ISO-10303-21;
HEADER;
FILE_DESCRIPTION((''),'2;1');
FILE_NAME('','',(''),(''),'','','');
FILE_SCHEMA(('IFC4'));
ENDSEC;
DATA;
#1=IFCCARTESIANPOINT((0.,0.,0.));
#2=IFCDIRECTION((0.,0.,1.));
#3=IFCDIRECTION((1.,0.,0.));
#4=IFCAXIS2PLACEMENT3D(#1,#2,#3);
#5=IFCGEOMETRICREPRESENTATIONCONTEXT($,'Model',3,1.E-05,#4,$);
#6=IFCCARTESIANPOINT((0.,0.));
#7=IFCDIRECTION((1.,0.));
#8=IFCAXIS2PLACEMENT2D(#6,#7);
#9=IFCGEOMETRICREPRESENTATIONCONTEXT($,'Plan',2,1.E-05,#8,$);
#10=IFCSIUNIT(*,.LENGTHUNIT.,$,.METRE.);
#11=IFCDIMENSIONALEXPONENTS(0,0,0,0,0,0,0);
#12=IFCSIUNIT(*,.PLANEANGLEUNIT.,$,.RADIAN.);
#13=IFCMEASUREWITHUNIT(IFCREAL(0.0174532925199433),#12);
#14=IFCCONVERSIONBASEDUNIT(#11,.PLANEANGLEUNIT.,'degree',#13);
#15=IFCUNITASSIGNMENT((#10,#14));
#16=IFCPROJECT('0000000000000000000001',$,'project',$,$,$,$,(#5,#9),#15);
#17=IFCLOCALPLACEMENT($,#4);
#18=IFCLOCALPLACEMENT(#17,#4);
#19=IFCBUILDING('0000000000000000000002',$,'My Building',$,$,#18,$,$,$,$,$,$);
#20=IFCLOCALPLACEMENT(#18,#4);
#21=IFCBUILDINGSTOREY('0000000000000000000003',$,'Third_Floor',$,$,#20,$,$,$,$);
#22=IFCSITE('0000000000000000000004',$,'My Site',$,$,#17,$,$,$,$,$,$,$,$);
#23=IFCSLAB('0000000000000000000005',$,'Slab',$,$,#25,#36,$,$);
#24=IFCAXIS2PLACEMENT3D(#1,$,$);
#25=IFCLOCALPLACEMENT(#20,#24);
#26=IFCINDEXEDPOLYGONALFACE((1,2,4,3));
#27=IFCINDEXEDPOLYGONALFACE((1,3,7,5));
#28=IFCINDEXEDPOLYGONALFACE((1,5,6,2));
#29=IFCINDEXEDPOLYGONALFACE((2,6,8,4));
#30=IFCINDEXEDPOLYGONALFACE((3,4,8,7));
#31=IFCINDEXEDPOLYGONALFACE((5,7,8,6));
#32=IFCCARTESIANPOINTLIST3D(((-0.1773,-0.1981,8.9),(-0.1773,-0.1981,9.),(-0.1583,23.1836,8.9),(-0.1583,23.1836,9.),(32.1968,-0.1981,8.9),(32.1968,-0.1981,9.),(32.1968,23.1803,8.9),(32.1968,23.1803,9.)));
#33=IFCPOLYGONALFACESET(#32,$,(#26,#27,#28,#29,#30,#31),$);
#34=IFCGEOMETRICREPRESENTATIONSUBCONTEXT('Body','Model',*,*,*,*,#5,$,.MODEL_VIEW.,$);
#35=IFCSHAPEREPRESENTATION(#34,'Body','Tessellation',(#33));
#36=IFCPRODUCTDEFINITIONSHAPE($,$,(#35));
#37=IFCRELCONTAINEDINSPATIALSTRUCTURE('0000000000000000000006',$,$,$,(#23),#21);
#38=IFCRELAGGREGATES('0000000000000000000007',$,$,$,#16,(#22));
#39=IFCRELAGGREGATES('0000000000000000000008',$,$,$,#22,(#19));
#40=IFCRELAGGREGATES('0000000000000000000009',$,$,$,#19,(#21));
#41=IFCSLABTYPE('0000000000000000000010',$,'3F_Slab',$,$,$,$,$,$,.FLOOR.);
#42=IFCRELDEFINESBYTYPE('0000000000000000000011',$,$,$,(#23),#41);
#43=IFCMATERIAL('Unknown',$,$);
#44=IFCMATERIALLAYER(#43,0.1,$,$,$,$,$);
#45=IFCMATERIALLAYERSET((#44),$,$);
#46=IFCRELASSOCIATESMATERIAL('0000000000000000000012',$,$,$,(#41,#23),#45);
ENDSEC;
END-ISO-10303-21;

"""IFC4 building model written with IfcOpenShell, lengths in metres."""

from ifc_helpers import new_model, entity, si_unit, converted_unit, frame, origin_with_axes, origin_2d_with_axis, place, context, subcontext, project, spatial, indexed_curve, outline, extrude, material, layer, layer_set, layer_usage, type_object, element, save


model = new_model("IFC4")

# Units and contexts
model_context = context("Model", 3, precision=1e-05, world=origin_with_axes())
plan_context = context("Plan", 2, precision=1e-05, world=origin_2d_with_axis())
body_context = subcontext(model_context, "Body", "Model", "MODEL_VIEW")
ifc_project = project(units=[si_unit("LENGTHUNIT", "METRE"), converted_unit("PLANEANGLEUNIT", "degree", entity("IfcReal", 0.0174532925199433), si_unit("PLANEANGLEUNIT", "RADIAN"), dimensions=[0, 0, 0, 0, 0, 0, 0])], contexts=[model_context, plan_context])

# Site, building, storey
site_placement = place(None, origin_with_axes())
site = spatial("IfcSite", under=ifc_project, at=site_placement, Name="My Site")
building_placement = place(site_placement, origin_with_axes())
building = spatial("IfcBuilding", under=site, at=building_placement, Name="My Building")
storey_placement = place(building_placement, origin_with_axes())
storey = spatial("IfcBuildingStorey", under=building, at=storey_placement, Name="Third_Floor")

# Slab
ifc_material = material(Name="Unknown")
ifc_layer = layer(ifc_material, 0.1)
ifc_layer_set = layer_set([ifc_layer])
ifc_layer_usage = layer_usage(ifc_layer_set, "AXIS3", "POSITIVE", -0.1)
slab_type = type_object("IfcSlabType", Name="3F_Slab", PredefinedType="FLOOR", material=ifc_layer_set)
slab_placement = place(storey_placement, frame((-0.1583, 23.1836, 9.0), z_axis=(0.0, 0.0, 1.0), x_axis=(1.0, 0.0, 0.0)))
element("IfcSlab", 1, at=slab_placement, inside=storey, type_object=slab_type, material=ifc_layer_usage, Name="Slab", context=body_context, shape_type="SweptSolid", body=[
    extrude(outline(indexed_curve([(0.0, 0.0), (32.3551, -0.0032), (32.3551, -23.3816), (-0.019, -23.3816), (0.0, 0.0)])), frame((0.0, 0.0, -0.1), z_axis=(0.0, 0.0, 1.0), x_axis=(1.0, 0.0, 0.0)), (0.0, 0.0, 1.0), 0.1),
])

save(model, "model.ifc")
